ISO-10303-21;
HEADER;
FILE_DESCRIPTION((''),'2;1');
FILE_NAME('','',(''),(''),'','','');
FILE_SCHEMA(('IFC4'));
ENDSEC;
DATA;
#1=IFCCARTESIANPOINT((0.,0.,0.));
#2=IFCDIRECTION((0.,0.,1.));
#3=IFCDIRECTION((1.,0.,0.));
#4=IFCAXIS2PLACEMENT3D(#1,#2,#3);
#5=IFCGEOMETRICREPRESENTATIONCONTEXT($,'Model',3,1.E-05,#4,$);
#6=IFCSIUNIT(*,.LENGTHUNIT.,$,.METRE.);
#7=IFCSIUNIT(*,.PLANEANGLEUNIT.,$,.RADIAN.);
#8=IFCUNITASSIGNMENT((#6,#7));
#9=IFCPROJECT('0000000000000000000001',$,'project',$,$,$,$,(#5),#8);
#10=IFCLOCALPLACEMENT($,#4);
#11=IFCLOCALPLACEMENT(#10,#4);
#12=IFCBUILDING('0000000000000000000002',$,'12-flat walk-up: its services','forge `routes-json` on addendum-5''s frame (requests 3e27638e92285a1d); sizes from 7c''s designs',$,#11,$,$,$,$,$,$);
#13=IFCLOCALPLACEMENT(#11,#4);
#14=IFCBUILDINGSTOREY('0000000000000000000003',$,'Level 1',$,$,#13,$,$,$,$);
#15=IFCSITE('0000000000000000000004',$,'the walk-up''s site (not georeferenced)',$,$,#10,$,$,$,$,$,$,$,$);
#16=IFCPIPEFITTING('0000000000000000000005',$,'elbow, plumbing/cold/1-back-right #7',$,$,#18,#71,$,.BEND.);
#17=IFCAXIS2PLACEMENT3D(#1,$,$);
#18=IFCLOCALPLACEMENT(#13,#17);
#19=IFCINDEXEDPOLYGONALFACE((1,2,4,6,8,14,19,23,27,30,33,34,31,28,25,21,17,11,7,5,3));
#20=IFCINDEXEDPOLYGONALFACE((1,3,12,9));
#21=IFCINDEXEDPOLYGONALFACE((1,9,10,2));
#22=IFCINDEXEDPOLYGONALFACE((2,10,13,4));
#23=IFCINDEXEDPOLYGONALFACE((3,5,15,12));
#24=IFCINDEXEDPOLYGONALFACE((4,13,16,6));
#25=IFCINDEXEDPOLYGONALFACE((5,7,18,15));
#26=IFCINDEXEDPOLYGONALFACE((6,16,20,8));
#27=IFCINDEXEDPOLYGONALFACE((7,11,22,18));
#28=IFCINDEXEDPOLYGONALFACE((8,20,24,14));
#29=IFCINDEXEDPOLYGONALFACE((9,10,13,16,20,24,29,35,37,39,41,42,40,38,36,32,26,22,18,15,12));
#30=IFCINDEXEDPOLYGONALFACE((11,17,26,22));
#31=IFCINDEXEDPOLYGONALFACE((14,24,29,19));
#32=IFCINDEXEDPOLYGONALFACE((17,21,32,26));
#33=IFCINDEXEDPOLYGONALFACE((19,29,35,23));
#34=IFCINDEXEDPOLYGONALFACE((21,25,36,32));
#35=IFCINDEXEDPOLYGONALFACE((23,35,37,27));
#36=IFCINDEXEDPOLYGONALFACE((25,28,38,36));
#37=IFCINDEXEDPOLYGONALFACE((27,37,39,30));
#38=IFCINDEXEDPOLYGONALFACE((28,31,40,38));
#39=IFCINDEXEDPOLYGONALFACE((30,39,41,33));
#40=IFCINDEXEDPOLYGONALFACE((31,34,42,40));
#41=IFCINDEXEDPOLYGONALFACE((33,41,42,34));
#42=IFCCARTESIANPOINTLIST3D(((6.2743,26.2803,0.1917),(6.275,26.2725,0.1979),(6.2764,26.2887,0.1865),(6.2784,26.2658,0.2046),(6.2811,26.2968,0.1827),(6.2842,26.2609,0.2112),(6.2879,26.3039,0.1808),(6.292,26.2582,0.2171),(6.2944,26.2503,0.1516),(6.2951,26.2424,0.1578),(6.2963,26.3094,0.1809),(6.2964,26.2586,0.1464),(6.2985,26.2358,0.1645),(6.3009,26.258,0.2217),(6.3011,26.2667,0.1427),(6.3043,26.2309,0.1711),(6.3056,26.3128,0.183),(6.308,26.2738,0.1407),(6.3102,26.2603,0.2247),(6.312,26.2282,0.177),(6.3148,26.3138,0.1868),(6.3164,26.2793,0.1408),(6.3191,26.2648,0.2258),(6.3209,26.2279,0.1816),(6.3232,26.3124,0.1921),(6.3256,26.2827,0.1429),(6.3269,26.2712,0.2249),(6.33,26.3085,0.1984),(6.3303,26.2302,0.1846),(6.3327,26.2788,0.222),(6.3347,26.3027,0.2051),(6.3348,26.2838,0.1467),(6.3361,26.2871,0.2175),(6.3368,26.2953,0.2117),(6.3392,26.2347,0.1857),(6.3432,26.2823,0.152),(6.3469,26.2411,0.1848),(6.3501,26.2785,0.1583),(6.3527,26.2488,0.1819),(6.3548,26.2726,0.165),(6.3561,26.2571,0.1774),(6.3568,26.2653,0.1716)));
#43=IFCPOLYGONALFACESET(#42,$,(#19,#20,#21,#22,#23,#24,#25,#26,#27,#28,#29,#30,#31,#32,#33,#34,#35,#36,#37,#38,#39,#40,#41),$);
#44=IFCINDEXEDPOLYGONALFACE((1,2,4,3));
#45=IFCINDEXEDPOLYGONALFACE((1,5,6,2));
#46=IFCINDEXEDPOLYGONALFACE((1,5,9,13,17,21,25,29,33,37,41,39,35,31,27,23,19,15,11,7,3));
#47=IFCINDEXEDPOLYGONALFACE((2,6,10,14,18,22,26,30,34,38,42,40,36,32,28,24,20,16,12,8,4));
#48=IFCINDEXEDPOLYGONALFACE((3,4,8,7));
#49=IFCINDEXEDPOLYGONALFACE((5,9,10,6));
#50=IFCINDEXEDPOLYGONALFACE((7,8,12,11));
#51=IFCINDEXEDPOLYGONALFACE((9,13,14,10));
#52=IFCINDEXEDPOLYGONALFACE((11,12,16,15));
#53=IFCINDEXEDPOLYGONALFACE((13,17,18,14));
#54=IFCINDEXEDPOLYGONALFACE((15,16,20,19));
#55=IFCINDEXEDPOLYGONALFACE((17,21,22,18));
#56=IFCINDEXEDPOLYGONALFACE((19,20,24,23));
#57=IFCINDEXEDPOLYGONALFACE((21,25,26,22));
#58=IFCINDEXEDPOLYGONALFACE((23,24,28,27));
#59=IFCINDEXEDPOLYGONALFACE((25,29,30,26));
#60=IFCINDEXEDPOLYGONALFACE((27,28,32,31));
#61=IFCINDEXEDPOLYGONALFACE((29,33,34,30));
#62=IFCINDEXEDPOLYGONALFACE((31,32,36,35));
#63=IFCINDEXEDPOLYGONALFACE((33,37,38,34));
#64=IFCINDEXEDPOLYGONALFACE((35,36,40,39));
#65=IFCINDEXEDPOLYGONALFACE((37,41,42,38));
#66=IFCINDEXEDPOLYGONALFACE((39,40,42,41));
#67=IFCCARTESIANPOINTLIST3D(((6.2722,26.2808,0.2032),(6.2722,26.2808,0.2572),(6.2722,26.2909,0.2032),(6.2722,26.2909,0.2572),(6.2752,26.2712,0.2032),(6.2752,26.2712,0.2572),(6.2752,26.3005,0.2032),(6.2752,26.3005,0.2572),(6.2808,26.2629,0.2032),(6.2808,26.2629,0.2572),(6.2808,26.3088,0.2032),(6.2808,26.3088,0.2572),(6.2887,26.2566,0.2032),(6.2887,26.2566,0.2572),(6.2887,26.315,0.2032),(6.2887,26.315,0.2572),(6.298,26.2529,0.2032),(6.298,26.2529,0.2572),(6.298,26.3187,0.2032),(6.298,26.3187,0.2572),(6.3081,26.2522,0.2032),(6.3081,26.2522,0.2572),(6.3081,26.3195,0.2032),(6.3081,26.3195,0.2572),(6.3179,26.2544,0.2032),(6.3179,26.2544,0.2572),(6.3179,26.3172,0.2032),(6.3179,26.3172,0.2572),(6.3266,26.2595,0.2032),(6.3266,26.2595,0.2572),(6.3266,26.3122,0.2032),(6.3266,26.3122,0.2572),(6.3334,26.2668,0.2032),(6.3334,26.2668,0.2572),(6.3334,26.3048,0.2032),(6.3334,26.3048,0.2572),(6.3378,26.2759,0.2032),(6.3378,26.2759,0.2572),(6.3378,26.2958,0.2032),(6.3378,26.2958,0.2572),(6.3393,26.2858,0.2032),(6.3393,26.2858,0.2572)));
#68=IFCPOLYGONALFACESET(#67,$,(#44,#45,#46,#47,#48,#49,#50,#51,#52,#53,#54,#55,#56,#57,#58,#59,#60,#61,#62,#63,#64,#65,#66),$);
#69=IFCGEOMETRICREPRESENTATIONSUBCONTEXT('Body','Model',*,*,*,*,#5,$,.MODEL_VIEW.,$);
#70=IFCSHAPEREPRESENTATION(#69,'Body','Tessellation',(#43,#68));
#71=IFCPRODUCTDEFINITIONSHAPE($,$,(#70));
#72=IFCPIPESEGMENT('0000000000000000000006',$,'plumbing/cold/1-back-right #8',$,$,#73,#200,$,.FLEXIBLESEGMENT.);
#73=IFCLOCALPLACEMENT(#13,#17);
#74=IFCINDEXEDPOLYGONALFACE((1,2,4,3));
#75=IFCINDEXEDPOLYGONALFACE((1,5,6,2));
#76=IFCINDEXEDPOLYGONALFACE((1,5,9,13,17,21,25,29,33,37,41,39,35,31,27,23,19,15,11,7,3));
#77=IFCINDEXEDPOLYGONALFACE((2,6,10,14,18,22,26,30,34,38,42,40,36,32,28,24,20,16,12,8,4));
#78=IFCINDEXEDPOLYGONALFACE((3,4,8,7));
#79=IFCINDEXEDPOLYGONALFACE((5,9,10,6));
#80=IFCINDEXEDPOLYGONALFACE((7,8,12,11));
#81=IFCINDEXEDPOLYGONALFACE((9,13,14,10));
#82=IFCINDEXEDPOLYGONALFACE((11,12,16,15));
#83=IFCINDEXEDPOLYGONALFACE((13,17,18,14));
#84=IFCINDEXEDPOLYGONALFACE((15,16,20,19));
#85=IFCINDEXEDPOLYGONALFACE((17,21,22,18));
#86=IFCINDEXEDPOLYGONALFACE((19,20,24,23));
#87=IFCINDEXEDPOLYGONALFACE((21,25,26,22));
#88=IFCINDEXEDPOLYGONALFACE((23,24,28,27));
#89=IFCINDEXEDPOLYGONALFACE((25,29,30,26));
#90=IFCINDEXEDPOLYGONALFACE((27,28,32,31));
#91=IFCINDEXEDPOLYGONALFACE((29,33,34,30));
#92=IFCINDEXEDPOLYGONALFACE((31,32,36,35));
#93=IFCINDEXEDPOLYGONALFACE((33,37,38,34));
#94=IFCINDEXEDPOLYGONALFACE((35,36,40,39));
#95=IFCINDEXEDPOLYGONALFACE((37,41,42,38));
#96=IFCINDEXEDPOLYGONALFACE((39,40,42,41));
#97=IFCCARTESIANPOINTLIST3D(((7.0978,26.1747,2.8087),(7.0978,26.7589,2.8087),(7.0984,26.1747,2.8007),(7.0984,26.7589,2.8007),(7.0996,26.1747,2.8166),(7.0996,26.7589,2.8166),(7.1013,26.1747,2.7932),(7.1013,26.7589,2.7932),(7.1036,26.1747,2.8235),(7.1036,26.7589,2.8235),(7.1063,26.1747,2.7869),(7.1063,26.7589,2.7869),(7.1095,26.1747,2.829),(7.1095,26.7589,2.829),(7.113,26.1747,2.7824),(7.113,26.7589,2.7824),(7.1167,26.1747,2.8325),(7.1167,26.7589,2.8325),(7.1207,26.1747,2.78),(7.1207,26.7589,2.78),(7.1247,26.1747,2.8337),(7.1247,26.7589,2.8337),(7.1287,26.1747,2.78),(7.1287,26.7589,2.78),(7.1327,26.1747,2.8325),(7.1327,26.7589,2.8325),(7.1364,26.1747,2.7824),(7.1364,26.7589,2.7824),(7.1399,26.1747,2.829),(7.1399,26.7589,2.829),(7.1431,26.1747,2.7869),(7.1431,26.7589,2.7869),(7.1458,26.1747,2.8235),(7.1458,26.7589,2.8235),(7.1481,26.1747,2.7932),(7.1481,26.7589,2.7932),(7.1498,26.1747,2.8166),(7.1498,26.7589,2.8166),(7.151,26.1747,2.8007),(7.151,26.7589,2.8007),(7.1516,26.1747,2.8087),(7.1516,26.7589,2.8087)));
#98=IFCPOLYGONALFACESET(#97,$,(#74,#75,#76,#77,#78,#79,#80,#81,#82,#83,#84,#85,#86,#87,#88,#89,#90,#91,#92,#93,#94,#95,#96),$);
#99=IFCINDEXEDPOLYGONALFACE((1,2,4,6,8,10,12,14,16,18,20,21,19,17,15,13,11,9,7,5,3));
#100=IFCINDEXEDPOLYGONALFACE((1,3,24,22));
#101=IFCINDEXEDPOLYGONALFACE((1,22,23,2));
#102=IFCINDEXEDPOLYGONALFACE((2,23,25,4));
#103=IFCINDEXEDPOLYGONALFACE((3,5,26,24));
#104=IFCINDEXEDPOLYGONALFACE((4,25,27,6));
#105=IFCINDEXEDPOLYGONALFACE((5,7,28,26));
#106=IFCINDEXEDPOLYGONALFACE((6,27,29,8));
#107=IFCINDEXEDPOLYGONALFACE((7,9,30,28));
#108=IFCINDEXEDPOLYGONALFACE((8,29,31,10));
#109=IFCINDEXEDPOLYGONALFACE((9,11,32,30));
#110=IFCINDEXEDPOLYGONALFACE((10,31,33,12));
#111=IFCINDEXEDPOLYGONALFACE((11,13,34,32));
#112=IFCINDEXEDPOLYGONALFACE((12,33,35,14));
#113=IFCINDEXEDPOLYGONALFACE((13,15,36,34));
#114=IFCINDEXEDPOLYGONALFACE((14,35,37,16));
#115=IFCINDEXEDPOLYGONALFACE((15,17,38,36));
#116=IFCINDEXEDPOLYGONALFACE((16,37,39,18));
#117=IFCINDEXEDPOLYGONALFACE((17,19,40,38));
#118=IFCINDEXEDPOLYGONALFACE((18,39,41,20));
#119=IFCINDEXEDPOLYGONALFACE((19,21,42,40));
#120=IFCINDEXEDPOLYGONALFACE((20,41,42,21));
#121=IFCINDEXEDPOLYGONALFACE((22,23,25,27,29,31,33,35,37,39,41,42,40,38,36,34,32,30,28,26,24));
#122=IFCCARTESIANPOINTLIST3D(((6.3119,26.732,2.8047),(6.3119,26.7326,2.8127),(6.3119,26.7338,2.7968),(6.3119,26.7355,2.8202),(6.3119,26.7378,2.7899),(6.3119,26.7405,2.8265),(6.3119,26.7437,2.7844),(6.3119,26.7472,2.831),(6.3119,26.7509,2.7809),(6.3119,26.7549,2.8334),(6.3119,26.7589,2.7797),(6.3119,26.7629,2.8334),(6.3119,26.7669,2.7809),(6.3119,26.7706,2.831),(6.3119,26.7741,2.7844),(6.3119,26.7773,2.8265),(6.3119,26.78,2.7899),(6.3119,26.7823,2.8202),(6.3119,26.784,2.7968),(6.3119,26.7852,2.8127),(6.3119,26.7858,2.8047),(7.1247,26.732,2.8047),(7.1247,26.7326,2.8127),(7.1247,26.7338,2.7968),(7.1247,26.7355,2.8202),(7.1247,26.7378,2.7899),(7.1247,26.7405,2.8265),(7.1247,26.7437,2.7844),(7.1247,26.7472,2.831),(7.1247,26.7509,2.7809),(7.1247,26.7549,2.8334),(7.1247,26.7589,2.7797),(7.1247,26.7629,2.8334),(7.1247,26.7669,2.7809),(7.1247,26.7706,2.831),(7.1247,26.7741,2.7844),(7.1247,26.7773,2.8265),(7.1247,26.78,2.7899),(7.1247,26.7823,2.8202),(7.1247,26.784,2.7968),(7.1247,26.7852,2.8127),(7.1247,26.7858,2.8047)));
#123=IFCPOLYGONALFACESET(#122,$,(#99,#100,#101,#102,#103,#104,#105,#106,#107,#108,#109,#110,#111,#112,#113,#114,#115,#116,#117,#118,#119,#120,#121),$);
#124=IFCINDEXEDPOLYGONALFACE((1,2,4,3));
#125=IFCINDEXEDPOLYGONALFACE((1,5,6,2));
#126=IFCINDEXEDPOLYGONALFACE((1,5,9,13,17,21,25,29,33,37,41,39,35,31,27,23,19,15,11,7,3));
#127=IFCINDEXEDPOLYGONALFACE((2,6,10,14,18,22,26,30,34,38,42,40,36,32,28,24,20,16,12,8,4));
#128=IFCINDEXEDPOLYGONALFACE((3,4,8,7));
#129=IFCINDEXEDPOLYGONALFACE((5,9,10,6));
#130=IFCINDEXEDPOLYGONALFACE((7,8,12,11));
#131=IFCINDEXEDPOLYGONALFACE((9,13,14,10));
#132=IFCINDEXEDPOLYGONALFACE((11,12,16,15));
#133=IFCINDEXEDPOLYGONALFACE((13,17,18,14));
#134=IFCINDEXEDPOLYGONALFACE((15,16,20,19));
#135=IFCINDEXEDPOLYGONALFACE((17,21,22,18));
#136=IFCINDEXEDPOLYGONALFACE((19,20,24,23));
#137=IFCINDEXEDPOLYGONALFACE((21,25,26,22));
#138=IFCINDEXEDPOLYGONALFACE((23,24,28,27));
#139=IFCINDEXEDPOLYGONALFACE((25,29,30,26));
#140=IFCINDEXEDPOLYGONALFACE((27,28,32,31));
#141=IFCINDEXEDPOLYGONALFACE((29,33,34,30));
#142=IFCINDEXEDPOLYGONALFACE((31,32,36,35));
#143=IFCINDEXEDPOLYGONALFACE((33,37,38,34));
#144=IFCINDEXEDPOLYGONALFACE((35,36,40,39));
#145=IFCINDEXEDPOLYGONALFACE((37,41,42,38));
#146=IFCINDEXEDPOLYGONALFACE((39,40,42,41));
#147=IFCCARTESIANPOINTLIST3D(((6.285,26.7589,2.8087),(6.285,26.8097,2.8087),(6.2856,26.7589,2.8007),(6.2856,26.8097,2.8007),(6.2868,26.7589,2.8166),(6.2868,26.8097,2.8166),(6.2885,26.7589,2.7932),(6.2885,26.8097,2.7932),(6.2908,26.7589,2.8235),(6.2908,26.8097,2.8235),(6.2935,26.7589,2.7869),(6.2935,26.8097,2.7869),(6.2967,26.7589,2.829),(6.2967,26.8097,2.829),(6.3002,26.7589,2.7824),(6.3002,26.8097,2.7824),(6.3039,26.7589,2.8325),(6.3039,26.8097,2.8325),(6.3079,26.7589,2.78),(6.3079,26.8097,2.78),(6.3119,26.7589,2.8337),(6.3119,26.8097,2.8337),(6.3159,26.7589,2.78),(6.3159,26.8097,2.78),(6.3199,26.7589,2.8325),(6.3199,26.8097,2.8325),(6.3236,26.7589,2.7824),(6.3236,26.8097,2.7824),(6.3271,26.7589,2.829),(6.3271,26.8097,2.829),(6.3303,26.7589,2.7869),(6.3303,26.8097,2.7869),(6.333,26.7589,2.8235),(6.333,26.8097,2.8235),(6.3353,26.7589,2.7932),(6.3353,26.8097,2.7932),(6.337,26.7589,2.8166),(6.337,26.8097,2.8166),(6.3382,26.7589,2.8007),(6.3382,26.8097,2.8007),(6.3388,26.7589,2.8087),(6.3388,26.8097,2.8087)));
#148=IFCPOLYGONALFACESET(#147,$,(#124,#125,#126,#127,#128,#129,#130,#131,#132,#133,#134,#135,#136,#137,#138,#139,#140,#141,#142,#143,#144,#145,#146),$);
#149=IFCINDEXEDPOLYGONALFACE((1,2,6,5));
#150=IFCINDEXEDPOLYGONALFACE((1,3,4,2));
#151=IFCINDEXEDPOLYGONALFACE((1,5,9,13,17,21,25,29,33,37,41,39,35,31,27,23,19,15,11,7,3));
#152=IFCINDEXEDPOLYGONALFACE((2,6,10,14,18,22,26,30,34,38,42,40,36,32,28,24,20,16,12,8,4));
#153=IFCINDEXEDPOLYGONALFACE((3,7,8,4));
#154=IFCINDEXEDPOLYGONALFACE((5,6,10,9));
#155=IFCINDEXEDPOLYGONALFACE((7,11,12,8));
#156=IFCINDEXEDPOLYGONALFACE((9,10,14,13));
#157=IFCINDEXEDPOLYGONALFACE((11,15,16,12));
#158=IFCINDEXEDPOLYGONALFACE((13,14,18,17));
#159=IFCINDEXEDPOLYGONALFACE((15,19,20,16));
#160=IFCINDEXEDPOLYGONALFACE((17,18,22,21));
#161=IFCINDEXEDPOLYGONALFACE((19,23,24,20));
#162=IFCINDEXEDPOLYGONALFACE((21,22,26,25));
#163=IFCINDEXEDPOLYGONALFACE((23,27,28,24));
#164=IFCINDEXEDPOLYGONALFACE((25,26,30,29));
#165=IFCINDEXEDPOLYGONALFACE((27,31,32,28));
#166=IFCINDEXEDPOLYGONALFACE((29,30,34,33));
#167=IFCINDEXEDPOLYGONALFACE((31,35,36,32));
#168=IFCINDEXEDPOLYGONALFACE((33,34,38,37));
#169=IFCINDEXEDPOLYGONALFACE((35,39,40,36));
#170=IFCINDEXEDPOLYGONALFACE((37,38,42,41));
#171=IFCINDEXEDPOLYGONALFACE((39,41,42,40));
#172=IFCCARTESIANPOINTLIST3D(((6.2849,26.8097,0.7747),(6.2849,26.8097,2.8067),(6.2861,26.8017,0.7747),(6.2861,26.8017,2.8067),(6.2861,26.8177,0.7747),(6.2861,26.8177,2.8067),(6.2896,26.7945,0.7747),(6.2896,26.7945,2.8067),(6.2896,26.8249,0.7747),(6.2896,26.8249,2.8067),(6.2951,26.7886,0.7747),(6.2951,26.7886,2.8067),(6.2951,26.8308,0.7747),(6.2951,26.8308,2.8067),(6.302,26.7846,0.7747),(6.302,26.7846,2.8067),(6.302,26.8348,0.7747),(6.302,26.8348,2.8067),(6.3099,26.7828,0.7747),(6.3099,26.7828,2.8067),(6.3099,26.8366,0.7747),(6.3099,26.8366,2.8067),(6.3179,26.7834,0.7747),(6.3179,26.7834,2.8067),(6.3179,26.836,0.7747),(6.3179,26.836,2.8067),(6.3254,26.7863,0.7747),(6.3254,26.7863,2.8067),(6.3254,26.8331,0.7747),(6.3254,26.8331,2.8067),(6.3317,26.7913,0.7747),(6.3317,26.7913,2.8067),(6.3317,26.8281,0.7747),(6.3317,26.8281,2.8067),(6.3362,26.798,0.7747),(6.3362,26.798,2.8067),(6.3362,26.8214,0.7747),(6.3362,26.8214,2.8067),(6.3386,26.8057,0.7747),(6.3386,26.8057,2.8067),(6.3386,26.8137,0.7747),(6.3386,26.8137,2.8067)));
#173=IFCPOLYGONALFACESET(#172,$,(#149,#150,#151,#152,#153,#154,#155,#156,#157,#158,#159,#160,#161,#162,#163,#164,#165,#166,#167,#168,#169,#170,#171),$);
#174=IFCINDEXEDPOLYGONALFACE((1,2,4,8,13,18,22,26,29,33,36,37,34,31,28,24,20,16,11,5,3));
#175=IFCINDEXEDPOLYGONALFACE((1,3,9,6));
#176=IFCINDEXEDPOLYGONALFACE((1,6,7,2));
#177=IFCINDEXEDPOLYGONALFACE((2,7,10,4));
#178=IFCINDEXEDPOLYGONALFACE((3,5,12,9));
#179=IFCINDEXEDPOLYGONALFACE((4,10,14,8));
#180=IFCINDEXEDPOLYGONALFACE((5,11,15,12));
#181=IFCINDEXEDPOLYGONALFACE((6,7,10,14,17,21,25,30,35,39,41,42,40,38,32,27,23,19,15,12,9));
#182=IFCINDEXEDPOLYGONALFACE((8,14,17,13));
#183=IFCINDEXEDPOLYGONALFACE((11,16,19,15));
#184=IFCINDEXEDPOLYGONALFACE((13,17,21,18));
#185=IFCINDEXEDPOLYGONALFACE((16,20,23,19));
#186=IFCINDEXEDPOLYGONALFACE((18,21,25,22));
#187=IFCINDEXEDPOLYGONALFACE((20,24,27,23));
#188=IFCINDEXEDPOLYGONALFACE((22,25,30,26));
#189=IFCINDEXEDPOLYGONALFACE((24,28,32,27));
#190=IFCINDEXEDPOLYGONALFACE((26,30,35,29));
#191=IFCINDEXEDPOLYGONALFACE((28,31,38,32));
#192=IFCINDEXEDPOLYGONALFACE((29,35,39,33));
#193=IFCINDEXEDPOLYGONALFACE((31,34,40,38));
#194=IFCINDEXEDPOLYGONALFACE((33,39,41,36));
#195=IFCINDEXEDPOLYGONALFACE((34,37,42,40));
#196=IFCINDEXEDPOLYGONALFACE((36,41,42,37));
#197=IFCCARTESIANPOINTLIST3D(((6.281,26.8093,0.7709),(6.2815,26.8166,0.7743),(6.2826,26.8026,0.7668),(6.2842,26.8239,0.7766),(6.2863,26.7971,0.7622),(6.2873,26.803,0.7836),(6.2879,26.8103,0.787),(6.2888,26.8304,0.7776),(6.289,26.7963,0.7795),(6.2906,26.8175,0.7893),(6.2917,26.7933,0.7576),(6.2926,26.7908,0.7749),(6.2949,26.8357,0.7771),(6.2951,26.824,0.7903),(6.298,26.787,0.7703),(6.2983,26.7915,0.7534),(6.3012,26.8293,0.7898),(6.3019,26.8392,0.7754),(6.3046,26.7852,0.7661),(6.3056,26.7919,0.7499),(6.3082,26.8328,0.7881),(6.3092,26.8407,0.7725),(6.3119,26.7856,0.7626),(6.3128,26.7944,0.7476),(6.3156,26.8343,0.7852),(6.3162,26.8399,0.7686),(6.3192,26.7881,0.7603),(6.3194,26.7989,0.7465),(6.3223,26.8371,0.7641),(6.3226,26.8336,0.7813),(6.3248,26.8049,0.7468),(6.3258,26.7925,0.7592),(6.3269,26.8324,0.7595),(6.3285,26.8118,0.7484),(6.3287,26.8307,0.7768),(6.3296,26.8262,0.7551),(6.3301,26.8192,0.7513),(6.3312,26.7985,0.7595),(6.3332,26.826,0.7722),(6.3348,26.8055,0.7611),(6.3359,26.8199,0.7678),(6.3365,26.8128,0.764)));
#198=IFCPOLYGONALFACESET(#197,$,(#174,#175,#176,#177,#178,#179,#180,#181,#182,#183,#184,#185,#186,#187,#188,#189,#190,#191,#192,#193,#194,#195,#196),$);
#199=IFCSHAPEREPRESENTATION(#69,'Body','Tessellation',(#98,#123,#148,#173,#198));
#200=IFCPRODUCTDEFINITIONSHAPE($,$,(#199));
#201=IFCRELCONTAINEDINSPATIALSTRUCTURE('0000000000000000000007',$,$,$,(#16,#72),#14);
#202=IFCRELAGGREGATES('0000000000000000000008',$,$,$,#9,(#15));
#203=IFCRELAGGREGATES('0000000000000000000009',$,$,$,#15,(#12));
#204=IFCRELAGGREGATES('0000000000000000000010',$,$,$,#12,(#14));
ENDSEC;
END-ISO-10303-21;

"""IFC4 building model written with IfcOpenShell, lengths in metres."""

from ifc_helpers import new_model, entity, si_unit, frame, origin_with_axes, place, context, subcontext, project, spatial, element, save


model = new_model("IFC4")

# Units and contexts
model_context = context("Model", 3, precision=1e-05, world=origin_with_axes())
body_context = subcontext(model_context, "Body", "Model", "MODEL_VIEW")
ifc_project = project(units=[si_unit("LENGTHUNIT", "METRE"), si_unit("PLANEANGLEUNIT", "RADIAN")], contexts=[model_context])

# Site, building, storey
site_placement = place(None, origin_with_axes())
site = spatial("IfcSite", under=ifc_project, at=site_placement, Name="the walk-up's site (not georeferenced)")
building_placement = place(site_placement, origin_with_axes())
building = spatial("IfcBuilding", under=site, at=building_placement, Name="12-flat walk-up: its services", Description="forge `routes-json` on addendum-5's frame (requests 3e27638e92285a1d); sizes from 7c's designs")
storey_placement = place(building_placement, origin_with_axes())
storey = spatial("IfcBuildingStorey", under=building, at=storey_placement, Name="Level 1")

# Pipe fitting
pipe_fitting_1_placement = place(storey_placement, frame((6.3256, 26.2558, 0.1631), z_axis=(0.0, 0.0, 1.0), x_axis=(1.0, 0.0, 0.0)))
element("IfcPipeFitting", 1, at=pipe_fitting_1_placement, inside=storey, Name="elbow, plumbing/cold/1-back-right #7", PredefinedType="BEND", context=body_context, shape_type="AdvancedSweptSolid", body=[
    entity("IfcSweptDiskSolid", entity("IfcPolyline", [entity("IfcCartesianPoint", [0.0, 0.0, 0.0]), entity("IfcCartesianPoint", [-0.02, 0.0301, 0.0401])]), 0.0337),
    entity("IfcSweptDiskSolid", entity("IfcPolyline", [entity("IfcCartesianPoint", [-0.02, 0.0301, 0.0401]), entity("IfcCartesianPoint", [-0.02, 0.0301, 0.0941])]), 0.0337),
])

# Pipe segment
pipe_segment_1_placement = place(storey_placement, frame((7.1247, 26.1747, 2.8067), z_axis=(0.0, 0.0, 1.0), x_axis=(1.0, 0.0, 0.0)))
element("IfcPipeSegment", 2, at=pipe_segment_1_placement, inside=storey, Name="plumbing/cold/1-back-right #8", PredefinedType="FLEXIBLESEGMENT", context=body_context, shape_type="AdvancedSweptSolid", body=[
    entity("IfcSweptDiskSolid", entity("IfcPolyline", [entity("IfcCartesianPoint", [0.0, 0.0, 0.0]), entity("IfcCartesianPoint", [0.0, 0.5842, 0.0])]), 0.027),
    entity("IfcSweptDiskSolid", entity("IfcPolyline", [entity("IfcCartesianPoint", [0.0, 0.5842, 0.0]), entity("IfcCartesianPoint", [-0.8128, 0.5842, 0.0])]), 0.027),
    entity("IfcSweptDiskSolid", entity("IfcPolyline", [entity("IfcCartesianPoint", [-0.8128, 0.5842, 0.0]), entity("IfcCartesianPoint", [-0.8128, 0.635, 0.0])]), 0.027),
    entity("IfcSweptDiskSolid", entity("IfcPolyline", [entity("IfcCartesianPoint", [-0.8128, 0.635, 0.0]), entity("IfcCartesianPoint", [-0.8128, 0.635, -2.032])]), 0.027),
    entity("IfcSweptDiskSolid", entity("IfcPolyline", [entity("IfcCartesianPoint", [-0.8128, 0.635, -2.032]), entity("IfcCartesianPoint", [-0.8191, 0.6414, -2.0447])]), 0.027),
])

save(model, "model.ifc")
